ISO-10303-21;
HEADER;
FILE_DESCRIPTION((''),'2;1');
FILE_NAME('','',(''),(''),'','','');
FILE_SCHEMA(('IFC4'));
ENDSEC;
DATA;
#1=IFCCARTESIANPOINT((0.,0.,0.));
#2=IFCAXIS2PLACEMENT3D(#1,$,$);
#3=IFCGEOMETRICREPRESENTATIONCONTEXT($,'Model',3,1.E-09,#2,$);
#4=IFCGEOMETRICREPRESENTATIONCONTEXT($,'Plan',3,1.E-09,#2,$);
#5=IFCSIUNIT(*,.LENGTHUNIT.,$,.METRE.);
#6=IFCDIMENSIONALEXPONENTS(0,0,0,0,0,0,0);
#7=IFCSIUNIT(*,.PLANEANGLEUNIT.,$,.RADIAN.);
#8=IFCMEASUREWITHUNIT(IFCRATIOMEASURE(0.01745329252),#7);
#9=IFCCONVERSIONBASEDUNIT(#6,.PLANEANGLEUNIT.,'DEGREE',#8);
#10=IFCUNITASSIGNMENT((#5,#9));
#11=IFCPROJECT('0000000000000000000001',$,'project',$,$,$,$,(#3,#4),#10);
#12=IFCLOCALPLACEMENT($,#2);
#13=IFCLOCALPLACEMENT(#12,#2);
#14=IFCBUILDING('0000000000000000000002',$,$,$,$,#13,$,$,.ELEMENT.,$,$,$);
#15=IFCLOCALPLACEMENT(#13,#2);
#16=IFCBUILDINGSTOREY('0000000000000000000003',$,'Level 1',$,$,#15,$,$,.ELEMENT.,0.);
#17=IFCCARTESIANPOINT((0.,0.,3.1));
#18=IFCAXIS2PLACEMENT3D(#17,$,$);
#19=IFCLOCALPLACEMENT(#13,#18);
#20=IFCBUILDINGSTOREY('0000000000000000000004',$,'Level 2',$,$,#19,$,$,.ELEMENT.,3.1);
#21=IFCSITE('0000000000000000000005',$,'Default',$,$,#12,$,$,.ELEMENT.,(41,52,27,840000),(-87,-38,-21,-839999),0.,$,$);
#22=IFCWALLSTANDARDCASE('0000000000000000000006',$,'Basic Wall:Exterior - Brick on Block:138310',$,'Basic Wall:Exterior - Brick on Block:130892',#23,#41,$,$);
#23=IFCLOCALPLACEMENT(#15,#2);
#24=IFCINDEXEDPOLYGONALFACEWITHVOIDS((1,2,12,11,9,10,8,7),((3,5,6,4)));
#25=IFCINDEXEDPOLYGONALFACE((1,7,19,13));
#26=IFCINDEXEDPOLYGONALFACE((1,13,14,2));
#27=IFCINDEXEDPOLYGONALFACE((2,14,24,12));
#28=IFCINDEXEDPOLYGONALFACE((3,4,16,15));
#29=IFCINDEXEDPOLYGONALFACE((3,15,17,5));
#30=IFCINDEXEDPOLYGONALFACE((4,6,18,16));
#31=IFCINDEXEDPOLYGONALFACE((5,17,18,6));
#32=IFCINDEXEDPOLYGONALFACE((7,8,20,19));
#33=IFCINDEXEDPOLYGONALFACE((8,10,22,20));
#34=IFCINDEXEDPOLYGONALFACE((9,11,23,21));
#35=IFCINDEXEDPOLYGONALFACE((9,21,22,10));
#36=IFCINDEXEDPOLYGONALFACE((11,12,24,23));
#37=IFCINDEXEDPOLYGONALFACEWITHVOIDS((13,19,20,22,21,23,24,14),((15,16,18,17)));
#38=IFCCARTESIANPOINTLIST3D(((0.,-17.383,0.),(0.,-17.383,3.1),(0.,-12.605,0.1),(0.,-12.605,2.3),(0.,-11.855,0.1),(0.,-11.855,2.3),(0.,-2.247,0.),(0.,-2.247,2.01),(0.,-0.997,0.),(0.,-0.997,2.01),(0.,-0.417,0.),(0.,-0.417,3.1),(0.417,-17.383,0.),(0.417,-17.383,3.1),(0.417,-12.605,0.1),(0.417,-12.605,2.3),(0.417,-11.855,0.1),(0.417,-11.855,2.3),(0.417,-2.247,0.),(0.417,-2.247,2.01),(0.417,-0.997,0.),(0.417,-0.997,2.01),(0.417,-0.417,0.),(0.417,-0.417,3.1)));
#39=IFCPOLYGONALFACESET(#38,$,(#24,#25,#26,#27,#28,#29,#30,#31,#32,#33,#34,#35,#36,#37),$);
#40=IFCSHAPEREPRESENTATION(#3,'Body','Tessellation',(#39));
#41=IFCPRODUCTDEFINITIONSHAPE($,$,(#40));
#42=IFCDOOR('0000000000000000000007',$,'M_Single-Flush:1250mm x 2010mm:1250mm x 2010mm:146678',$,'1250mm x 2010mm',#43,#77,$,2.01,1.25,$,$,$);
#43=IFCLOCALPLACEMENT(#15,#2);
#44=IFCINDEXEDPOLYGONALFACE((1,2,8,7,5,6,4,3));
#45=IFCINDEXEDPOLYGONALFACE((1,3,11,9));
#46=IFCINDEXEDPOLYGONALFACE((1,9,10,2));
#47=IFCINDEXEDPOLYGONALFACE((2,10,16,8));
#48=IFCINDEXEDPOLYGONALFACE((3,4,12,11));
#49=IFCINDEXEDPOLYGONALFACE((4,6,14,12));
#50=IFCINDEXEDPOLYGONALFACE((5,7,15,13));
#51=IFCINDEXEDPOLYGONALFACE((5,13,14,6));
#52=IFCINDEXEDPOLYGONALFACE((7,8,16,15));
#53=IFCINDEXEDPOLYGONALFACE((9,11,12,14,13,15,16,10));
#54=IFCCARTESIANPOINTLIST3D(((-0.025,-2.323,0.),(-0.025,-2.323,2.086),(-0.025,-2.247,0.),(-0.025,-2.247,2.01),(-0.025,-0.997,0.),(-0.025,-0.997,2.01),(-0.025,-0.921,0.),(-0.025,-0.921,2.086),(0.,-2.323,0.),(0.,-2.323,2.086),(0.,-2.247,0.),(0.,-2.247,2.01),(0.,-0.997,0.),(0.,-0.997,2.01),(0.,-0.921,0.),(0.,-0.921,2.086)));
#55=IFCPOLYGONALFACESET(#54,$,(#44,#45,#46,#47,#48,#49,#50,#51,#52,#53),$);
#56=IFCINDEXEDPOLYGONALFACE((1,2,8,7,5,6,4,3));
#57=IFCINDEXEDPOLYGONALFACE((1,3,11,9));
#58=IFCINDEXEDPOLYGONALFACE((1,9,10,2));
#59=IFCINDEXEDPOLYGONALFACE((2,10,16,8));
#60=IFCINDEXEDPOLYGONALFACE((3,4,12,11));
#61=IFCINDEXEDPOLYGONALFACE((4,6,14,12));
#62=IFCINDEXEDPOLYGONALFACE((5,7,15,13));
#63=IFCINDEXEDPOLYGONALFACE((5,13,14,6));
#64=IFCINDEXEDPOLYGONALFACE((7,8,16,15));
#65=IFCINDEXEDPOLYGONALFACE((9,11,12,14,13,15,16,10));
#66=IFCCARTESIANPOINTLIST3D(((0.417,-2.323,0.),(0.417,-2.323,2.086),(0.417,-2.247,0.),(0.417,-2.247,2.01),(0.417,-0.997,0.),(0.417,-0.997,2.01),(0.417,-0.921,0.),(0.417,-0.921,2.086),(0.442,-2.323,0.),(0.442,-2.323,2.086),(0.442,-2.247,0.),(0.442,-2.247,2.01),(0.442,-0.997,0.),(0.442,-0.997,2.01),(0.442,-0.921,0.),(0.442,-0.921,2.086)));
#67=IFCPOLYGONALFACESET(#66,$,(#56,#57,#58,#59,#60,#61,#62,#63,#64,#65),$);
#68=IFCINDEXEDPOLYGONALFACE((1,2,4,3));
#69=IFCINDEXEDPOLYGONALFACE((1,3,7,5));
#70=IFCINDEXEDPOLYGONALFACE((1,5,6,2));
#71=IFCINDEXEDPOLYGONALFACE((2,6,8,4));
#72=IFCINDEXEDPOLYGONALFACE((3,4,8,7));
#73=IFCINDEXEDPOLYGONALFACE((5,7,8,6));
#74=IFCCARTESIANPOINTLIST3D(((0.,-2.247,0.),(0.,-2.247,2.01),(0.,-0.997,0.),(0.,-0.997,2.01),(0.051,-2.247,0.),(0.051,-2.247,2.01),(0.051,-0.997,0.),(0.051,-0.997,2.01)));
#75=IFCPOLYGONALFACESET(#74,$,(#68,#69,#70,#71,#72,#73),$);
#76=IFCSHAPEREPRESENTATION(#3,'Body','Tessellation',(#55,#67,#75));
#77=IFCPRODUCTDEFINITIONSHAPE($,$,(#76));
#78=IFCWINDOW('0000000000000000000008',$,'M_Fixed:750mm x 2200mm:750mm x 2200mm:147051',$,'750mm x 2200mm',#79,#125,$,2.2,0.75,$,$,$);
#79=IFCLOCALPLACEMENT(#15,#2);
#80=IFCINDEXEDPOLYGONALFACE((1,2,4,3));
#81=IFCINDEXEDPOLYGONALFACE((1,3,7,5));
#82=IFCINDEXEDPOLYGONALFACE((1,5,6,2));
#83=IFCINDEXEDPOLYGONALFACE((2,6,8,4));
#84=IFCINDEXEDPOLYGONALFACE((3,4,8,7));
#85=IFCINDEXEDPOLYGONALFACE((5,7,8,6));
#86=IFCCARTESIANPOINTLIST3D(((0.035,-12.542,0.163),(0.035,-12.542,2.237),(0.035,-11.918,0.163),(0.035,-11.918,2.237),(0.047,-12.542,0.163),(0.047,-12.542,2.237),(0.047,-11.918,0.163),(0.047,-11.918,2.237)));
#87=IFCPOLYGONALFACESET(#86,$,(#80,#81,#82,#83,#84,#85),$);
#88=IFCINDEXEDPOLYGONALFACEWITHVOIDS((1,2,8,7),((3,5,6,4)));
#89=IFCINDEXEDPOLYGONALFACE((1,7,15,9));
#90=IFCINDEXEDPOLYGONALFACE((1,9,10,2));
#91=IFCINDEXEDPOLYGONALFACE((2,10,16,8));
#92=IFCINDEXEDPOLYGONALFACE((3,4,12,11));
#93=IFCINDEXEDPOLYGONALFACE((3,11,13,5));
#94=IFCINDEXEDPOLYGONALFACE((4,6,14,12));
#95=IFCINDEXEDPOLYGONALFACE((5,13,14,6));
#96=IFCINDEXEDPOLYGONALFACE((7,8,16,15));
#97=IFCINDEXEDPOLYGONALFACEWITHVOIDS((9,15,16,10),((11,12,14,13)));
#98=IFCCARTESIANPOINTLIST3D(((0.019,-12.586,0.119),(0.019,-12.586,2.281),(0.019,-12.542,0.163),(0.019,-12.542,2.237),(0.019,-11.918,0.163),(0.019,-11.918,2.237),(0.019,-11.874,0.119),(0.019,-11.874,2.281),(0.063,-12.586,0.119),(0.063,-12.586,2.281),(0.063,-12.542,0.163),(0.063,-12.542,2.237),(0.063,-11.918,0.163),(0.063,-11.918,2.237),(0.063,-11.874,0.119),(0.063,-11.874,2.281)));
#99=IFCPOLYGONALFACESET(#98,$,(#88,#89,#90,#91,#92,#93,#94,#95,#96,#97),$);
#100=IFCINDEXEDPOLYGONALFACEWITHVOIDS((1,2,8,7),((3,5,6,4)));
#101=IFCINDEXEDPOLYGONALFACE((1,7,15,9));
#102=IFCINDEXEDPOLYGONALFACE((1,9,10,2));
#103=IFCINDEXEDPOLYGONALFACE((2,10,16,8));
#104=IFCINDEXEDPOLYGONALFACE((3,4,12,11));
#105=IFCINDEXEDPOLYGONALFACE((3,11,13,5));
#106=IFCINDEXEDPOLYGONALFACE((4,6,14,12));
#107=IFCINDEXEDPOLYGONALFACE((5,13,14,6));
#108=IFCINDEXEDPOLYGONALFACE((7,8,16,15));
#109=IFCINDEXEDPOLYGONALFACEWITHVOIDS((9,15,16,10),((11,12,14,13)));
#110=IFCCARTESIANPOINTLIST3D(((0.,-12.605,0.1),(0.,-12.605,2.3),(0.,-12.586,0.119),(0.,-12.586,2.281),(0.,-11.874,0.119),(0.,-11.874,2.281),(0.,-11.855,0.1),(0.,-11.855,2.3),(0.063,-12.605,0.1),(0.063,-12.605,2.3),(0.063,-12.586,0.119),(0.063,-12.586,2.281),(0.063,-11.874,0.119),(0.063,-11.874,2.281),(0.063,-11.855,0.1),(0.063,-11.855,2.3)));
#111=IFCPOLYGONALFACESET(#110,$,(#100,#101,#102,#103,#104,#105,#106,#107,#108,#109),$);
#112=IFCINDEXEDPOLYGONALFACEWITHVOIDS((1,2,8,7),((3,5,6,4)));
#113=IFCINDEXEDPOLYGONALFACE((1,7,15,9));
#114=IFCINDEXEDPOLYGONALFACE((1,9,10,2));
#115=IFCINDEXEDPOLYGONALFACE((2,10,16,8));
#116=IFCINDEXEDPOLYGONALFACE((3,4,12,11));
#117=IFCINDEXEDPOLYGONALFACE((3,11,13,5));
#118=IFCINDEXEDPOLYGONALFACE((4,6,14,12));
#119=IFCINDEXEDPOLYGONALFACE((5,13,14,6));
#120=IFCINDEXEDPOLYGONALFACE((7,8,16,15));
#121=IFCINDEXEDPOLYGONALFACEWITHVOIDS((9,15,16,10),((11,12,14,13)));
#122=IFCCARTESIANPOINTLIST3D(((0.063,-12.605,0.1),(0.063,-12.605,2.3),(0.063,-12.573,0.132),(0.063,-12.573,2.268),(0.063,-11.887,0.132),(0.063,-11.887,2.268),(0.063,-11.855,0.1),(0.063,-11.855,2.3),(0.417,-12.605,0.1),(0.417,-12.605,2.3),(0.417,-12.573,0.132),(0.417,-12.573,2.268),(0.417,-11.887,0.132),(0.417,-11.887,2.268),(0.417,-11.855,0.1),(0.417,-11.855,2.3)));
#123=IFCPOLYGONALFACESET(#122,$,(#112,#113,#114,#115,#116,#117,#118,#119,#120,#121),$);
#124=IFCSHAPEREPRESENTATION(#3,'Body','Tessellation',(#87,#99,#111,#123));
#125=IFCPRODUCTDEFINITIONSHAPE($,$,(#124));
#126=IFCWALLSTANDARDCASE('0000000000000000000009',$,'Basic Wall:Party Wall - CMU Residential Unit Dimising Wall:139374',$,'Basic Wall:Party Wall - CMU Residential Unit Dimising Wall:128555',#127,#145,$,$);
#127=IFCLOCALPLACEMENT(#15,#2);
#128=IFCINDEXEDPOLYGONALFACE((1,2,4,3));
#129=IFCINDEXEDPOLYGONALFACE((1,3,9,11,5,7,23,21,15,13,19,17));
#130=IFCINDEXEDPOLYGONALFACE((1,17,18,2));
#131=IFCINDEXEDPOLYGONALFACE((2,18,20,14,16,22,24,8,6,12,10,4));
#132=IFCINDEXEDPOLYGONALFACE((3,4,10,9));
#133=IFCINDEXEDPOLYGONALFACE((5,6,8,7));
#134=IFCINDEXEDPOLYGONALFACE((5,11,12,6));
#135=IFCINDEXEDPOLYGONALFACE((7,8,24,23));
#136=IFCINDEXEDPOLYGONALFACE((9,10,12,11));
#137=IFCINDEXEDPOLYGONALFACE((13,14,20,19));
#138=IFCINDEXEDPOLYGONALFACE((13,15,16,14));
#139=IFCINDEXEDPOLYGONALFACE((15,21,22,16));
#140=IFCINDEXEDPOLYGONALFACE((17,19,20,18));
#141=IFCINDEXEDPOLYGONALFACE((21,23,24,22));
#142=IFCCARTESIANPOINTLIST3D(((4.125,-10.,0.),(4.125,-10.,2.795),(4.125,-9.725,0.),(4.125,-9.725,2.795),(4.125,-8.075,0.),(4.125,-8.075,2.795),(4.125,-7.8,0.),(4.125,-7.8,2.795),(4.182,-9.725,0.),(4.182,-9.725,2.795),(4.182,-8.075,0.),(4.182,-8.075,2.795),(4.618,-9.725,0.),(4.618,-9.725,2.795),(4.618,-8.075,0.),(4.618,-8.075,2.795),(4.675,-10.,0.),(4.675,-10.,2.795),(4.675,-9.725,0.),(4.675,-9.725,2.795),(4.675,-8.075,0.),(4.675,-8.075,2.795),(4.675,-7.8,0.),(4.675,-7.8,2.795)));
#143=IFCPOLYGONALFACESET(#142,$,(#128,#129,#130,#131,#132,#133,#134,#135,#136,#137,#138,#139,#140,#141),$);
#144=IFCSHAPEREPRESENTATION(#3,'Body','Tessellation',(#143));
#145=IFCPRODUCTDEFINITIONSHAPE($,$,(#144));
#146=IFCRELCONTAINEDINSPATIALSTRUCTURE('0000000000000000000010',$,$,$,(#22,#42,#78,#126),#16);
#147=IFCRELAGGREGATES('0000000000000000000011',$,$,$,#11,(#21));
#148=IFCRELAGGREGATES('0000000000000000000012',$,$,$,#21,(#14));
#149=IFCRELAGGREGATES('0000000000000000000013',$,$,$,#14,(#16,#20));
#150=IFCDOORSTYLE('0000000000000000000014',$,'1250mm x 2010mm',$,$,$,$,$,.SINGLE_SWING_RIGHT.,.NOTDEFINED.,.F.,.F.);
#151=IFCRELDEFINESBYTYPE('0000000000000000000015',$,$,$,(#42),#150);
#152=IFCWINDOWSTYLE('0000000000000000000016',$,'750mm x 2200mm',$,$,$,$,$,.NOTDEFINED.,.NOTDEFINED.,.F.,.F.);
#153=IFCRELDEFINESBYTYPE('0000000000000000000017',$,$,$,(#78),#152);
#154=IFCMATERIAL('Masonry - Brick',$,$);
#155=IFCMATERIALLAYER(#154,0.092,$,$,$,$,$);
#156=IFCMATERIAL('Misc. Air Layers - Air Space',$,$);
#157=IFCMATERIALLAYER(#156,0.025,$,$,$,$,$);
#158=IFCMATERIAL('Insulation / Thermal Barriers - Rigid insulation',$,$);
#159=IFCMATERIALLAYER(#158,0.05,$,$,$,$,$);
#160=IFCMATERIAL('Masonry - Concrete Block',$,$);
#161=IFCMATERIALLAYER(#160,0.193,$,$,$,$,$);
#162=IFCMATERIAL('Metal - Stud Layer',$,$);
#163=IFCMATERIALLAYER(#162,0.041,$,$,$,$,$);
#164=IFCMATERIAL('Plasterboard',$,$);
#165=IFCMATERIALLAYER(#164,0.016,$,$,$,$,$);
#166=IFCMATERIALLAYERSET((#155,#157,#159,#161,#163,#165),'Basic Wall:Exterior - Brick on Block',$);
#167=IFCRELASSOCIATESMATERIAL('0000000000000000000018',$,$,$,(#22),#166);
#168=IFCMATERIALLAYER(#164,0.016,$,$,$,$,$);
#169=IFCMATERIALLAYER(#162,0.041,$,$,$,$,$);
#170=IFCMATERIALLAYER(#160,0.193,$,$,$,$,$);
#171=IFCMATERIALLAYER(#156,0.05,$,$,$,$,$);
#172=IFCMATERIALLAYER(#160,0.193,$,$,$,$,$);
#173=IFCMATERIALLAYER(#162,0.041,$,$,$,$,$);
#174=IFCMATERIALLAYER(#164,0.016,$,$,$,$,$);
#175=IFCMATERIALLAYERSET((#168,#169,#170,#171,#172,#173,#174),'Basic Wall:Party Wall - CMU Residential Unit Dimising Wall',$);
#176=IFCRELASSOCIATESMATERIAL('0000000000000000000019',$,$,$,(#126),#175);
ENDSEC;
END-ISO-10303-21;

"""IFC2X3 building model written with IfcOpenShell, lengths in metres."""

from ifc_helpers import new_model, entity, si_unit, converted_unit, frame, frame_2d, origin, origin_2d_with_axis, place, context, project, spatial, polyline, rectangle, outline, extrude, clip, bounded_halfspace, source, transform, mapped, material, layer, layer_set, layer_usage, type_object, type_shapes, element, fill, save


model = new_model("IFC2X3")

# Units and contexts
model_context = context("Model", 3, precision=1e-09, world=origin())
plan_context = context("Plan", 3, precision=1e-09, world=origin())
ifc_project = project(units=[si_unit("LENGTHUNIT", "METRE"), converted_unit("PLANEANGLEUNIT", "DEGREE", entity("IfcRatioMeasure", 0.01745329252), si_unit("PLANEANGLEUNIT", "RADIAN"), dimensions=[0, 0, 0, 0, 0, 0, 0])], contexts=[model_context, plan_context])

# Site, building, storey
site_placement = place(None, origin())
site = spatial("IfcSite", under=ifc_project, at=site_placement, Name="Default", CompositionType="ELEMENT", RefLatitude=(41, 52, 27, 840000), RefLongitude=(-87, -38, -21, -839999), RefElevation=0.0)
building_placement = place(site_placement, origin())
building = spatial("IfcBuilding", under=site, at=building_placement, CompositionType="ELEMENT")
storey_1_placement = place(building_placement, origin())
storey_1 = spatial("IfcBuildingStorey", under=building, at=storey_1_placement, Name="Level 1", CompositionType="ELEMENT", Elevation=0.0)

# Shared definitions
ifc_material_1 = material(Name="Masonry - Brick")
ifc_layer_1 = layer(ifc_material_1, 0.092)
ifc_material_2 = material(Name="Misc. Air Layers - Air Space")
ifc_layer_2 = layer(ifc_material_2, 0.025)
ifc_material_3 = material(Name="Insulation / Thermal Barriers - Rigid insulation")
ifc_layer_3 = layer(ifc_material_3, 0.05)
ifc_material_4 = material(Name="Masonry - Concrete Block")
ifc_layer_4 = layer(ifc_material_4, 0.193)
ifc_material_5 = material(Name="Metal - Stud Layer")
ifc_layer_5 = layer(ifc_material_5, 0.041)
ifc_material_6 = material(Name="Plasterboard")
ifc_layer_6 = layer(ifc_material_6, 0.016)
ifc_layer_set_1 = layer_set([ifc_layer_1, ifc_layer_2, ifc_layer_3, ifc_layer_4, ifc_layer_5, ifc_layer_6], Name="Basic Wall:Exterior - Brick on Block")

# Wall, openings, door, window
ifc_layer_usage_1 = layer_usage(ifc_layer_set_1, "AXIS2", "NEGATIVE", 0.2085)
wall_1_placement = place(storey_1_placement, frame((0.2085, -17.383, 0.0), z_axis=(0.0, 0.0, 1.0), x_axis=(0.0, 1.0, 0.0)))
wall_1 = element("IfcWallStandardCase", 1, at=wall_1_placement, inside=storey_1, material=ifc_layer_usage_1, Name="Basic Wall:Exterior - Brick on Block:138310", ObjectType="Basic Wall:Exterior - Brick on Block:130892", context=model_context, shape_type="SweptSolid", body=[
    extrude(rectangle(XDim=16.966, YDim=0.417, at=frame_2d((8.483, 0.0), x_axis=(-1.0, 0.0))), origin(), (0.0, 0.0, 1.0), 3.1),
])
opening_1_placement = place(wall_1_placement, frame((15.136, -0.2085, 0.0)))
opening_1 = element("IfcOpeningElement", 2, at=opening_1_placement, cuts=wall_1, ObjectType="Opening", context=model_context, shape_type="SweptSolid", body=[
    extrude(rectangle(XDim=1.25, YDim=2.01, at=frame_2d((1.005, 0.625), x_axis=(0.0, 1.0))), frame((0.0, 0.0, 0.0), z_axis=(0.0, 1.0, 0.0), x_axis=(0.0, 0.0, 1.0)), (0.0, 0.0, 1.0), 0.417),
])
opening_2_placement = place(wall_1_placement, frame((4.778, -0.2085, 0.1)))
opening_2 = element("IfcOpeningElement", 3, at=opening_2_placement, cuts=wall_1, ObjectType="Opening", context=model_context, shape_type="SweptSolid", body=[
    extrude(rectangle(XDim=2.2, YDim=0.75, at=frame_2d((1.1, 0.375), x_axis=(1.0, 0.0))), frame((0.0, 0.0, 0.0), z_axis=(0.0, 1.0, 0.0), x_axis=(0.0, 0.0, 1.0)), (0.0, 0.0, 1.0), 0.417),
])
door_style_1 = type_object("IfcDoorStyle", Name="1250mm x 2010mm", ConstructionType="NOTDEFINED", OperationType="SINGLE_SWING_RIGHT", ParameterTakesPrecedence=False, Sizeable=False)
shared_shape_1 = source(origin(), model_context, "Body", "SweptSolid", [
    extrude(outline(polyline([(-0.701, -1.062), (0.701, -1.062), (0.701, 1.024), (0.625, 1.024), (0.625, -0.986), (-0.625, -0.986), (-0.625, 1.024), (-0.701, 1.024), (-0.701, -1.062)])), frame((0.625, 0.417, 1.024), z_axis=(0.0, 1.0, 0.0), x_axis=(1.0, 0.0, 0.0)), (0.0, 0.0, 1.0), 0.025),
    extrude(outline(polyline([(-1.062, -0.701), (1.024, -0.701), (1.024, -0.625), (-0.986, -0.625), (-0.986, 0.625), (1.024, 0.625), (1.024, 0.701), (-1.062, 0.701), (-1.062, -0.701)])), frame((0.625, -0.025, 1.024), z_axis=(0.0, 1.0, 0.0), x_axis=(0.0, 0.0, -1.0)), (0.0, 0.0, 1.0), 0.025),
    extrude(rectangle(XDim=0.051, YDim=1.25, at=origin_2d_with_axis()), frame((0.625, 0.3915, 0.0), z_axis=(0.0, 0.0, 1.0), x_axis=(0.0, 1.0, 0.0)), (0.0, 0.0, 1.0), 2.01),
])
type_shapes(door_style_1, [shared_shape_1])
door_1_placement = place(opening_1_placement, origin())
door_1 = element("IfcDoor", 4, at=door_1_placement, inside=storey_1, type_object=door_style_1, Name="M_Single-Flush:1250mm x 2010mm:1250mm x 2010mm:146678", ObjectType="1250mm x 2010mm", OverallHeight=2.01, OverallWidth=1.25, context=model_context, shape_type="MappedRepresentation", body=[
    mapped(shared_shape_1, transform((0.0, 0.0, 0.0), scale=1.0)),
])
fill(opening_1, door_1)
window_style_1 = type_object("IfcWindowStyle", Name="750mm x 2200mm", ConstructionType="NOTDEFINED", OperationType="NOTDEFINED", ParameterTakesPrecedence=False, Sizeable=False)
shared_shape_2 = source(origin(), model_context, "Body", "SweptSolid", [
    extrude(rectangle(XDim=0.012, YDim=0.624, at=origin_2d_with_axis()), frame((0.375, 0.376, 0.063), z_axis=(0.0, 0.0, 1.0), x_axis=(0.0, -1.0, 0.0)), (0.0, 0.0, 1.0), 2.074),
    extrude(outline(polyline([(-0.356, -1.081), (0.356, -1.081), (0.356, 1.081), (-0.356, 1.081), (-0.356, -1.081)]), holes=[polyline([(-0.312, -1.037), (-0.312, 1.037), (0.312, 1.037), (0.312, -1.037), (-0.312, -1.037)])]), frame((0.375, 0.354, 1.1), z_axis=(0.0, 1.0, 0.0), x_axis=(1.0, 0.0, 0.0)), (0.0, 0.0, 1.0), 0.044),
    extrude(outline(polyline([(-0.375, -1.1), (0.375, -1.1), (0.375, 1.1), (-0.375, 1.1), (-0.375, -1.1)]), holes=[polyline([(-0.356, -1.081), (-0.356, 1.081), (0.356, 1.081), (0.356, -1.081), (-0.356, -1.081)])]), frame((0.375, 0.354, 1.1), z_axis=(0.0, 1.0, 0.0), x_axis=(1.0, 0.0, 0.0)), (0.0, 0.0, 1.0), 0.063),
    extrude(outline(polyline([(-0.375, -1.1), (0.375, -1.1), (0.375, 1.1), (-0.375, 1.1), (-0.375, -1.1)]), holes=[polyline([(-0.343, -1.068), (-0.343, 1.068), (0.343, 1.068), (0.343, -1.068), (-0.343, -1.068)])]), frame((0.375, 0.0, 1.1), z_axis=(0.0, 1.0, 0.0), x_axis=(1.0, 0.0, 0.0)), (0.0, 0.0, 1.0), 0.354),
])
type_shapes(window_style_1, [shared_shape_2])
window_1_placement = place(opening_2_placement, origin())
window_1 = element("IfcWindow", 5, at=window_1_placement, inside=storey_1, type_object=window_style_1, Name="M_Fixed:750mm x 2200mm:750mm x 2200mm:147051", ObjectType="750mm x 2200mm", OverallHeight=2.2, OverallWidth=0.75, context=model_context, shape_type="MappedRepresentation", body=[
    mapped(shared_shape_2, transform((0.0, 0.0, 0.0), scale=1.0)),
])
fill(opening_2, window_1)

# Wall
ifc_layer_7 = layer(ifc_material_6, 0.016)
ifc_layer_8 = layer(ifc_material_5, 0.041)
ifc_layer_9 = layer(ifc_material_4, 0.193)
ifc_layer_10 = layer(ifc_material_2, 0.05)
ifc_layer_11 = layer(ifc_material_4, 0.193)
ifc_layer_12 = layer(ifc_material_5, 0.041)
ifc_layer_13 = layer(ifc_material_6, 0.016)
ifc_layer_set_2 = layer_set([ifc_layer_7, ifc_layer_8, ifc_layer_9, ifc_layer_10, ifc_layer_11, ifc_layer_12, ifc_layer_13], Name="Basic Wall:Party Wall - CMU Residential Unit Dimising Wall")
ifc_layer_usage_2 = layer_usage(ifc_layer_set_2, "AXIS2", "NEGATIVE", 0.275)
wall_2_placement = place(storey_1_placement, frame((4.4, -10.0, 0.0), z_axis=(0.0, 0.0, 1.0), x_axis=(0.0, 1.0, 0.0)))
element("IfcWallStandardCase", 6, at=wall_2_placement, inside=storey_1, material=ifc_layer_usage_2, Name="Basic Wall:Party Wall - CMU Residential Unit Dimising Wall:139374", ObjectType="Basic Wall:Party Wall - CMU Residential Unit Dimising Wall:128555", context=model_context, shape_type="Clipping", body=[
    clip(clip(extrude(rectangle(XDim=2.2, YDim=0.55, at=frame_2d((1.1, 0.0), x_axis=(-1.0, 0.0))), origin(), (0.0, 0.0, 1.0), 2.795), bounded_halfspace(frame((1.925, 0.218, 0.0), z_axis=(0.0, -1.0, 0.0), x_axis=(1.0, 0.0, 0.0)), True, frame((1.925, 0.218, 0.0), z_axis=(0.0, -1.0, 0.0), x_axis=(1.0, 0.0, 0.0)), polyline([(0.0, 0.0), (0.0, 2.795), (-1.65, 2.795), (-1.65, 0.0), (0.0, 0.0)]))), bounded_halfspace(frame((0.275, -0.218, 0.0), z_axis=(0.0, 1.0, 0.0), x_axis=(-1.0, 0.0, 0.0)), True, frame((0.275, -0.218, 0.0), z_axis=(0.0, 1.0, 0.0), x_axis=(-1.0, 0.0, 0.0)), polyline([(0.0, 0.0), (0.0, 2.795), (-1.65, 2.795), (-1.65, 0.0), (0.0, 0.0)]))),
])

# Shared definitions
storey_2_placement = place(building_placement, frame((0.0, 0.0, 3.1)))
storey_2 = spatial("IfcBuildingStorey", under=building, at=storey_2_placement, Name="Level 2", CompositionType="ELEMENT", Elevation=3.1)

save(model, "model.ifc")
